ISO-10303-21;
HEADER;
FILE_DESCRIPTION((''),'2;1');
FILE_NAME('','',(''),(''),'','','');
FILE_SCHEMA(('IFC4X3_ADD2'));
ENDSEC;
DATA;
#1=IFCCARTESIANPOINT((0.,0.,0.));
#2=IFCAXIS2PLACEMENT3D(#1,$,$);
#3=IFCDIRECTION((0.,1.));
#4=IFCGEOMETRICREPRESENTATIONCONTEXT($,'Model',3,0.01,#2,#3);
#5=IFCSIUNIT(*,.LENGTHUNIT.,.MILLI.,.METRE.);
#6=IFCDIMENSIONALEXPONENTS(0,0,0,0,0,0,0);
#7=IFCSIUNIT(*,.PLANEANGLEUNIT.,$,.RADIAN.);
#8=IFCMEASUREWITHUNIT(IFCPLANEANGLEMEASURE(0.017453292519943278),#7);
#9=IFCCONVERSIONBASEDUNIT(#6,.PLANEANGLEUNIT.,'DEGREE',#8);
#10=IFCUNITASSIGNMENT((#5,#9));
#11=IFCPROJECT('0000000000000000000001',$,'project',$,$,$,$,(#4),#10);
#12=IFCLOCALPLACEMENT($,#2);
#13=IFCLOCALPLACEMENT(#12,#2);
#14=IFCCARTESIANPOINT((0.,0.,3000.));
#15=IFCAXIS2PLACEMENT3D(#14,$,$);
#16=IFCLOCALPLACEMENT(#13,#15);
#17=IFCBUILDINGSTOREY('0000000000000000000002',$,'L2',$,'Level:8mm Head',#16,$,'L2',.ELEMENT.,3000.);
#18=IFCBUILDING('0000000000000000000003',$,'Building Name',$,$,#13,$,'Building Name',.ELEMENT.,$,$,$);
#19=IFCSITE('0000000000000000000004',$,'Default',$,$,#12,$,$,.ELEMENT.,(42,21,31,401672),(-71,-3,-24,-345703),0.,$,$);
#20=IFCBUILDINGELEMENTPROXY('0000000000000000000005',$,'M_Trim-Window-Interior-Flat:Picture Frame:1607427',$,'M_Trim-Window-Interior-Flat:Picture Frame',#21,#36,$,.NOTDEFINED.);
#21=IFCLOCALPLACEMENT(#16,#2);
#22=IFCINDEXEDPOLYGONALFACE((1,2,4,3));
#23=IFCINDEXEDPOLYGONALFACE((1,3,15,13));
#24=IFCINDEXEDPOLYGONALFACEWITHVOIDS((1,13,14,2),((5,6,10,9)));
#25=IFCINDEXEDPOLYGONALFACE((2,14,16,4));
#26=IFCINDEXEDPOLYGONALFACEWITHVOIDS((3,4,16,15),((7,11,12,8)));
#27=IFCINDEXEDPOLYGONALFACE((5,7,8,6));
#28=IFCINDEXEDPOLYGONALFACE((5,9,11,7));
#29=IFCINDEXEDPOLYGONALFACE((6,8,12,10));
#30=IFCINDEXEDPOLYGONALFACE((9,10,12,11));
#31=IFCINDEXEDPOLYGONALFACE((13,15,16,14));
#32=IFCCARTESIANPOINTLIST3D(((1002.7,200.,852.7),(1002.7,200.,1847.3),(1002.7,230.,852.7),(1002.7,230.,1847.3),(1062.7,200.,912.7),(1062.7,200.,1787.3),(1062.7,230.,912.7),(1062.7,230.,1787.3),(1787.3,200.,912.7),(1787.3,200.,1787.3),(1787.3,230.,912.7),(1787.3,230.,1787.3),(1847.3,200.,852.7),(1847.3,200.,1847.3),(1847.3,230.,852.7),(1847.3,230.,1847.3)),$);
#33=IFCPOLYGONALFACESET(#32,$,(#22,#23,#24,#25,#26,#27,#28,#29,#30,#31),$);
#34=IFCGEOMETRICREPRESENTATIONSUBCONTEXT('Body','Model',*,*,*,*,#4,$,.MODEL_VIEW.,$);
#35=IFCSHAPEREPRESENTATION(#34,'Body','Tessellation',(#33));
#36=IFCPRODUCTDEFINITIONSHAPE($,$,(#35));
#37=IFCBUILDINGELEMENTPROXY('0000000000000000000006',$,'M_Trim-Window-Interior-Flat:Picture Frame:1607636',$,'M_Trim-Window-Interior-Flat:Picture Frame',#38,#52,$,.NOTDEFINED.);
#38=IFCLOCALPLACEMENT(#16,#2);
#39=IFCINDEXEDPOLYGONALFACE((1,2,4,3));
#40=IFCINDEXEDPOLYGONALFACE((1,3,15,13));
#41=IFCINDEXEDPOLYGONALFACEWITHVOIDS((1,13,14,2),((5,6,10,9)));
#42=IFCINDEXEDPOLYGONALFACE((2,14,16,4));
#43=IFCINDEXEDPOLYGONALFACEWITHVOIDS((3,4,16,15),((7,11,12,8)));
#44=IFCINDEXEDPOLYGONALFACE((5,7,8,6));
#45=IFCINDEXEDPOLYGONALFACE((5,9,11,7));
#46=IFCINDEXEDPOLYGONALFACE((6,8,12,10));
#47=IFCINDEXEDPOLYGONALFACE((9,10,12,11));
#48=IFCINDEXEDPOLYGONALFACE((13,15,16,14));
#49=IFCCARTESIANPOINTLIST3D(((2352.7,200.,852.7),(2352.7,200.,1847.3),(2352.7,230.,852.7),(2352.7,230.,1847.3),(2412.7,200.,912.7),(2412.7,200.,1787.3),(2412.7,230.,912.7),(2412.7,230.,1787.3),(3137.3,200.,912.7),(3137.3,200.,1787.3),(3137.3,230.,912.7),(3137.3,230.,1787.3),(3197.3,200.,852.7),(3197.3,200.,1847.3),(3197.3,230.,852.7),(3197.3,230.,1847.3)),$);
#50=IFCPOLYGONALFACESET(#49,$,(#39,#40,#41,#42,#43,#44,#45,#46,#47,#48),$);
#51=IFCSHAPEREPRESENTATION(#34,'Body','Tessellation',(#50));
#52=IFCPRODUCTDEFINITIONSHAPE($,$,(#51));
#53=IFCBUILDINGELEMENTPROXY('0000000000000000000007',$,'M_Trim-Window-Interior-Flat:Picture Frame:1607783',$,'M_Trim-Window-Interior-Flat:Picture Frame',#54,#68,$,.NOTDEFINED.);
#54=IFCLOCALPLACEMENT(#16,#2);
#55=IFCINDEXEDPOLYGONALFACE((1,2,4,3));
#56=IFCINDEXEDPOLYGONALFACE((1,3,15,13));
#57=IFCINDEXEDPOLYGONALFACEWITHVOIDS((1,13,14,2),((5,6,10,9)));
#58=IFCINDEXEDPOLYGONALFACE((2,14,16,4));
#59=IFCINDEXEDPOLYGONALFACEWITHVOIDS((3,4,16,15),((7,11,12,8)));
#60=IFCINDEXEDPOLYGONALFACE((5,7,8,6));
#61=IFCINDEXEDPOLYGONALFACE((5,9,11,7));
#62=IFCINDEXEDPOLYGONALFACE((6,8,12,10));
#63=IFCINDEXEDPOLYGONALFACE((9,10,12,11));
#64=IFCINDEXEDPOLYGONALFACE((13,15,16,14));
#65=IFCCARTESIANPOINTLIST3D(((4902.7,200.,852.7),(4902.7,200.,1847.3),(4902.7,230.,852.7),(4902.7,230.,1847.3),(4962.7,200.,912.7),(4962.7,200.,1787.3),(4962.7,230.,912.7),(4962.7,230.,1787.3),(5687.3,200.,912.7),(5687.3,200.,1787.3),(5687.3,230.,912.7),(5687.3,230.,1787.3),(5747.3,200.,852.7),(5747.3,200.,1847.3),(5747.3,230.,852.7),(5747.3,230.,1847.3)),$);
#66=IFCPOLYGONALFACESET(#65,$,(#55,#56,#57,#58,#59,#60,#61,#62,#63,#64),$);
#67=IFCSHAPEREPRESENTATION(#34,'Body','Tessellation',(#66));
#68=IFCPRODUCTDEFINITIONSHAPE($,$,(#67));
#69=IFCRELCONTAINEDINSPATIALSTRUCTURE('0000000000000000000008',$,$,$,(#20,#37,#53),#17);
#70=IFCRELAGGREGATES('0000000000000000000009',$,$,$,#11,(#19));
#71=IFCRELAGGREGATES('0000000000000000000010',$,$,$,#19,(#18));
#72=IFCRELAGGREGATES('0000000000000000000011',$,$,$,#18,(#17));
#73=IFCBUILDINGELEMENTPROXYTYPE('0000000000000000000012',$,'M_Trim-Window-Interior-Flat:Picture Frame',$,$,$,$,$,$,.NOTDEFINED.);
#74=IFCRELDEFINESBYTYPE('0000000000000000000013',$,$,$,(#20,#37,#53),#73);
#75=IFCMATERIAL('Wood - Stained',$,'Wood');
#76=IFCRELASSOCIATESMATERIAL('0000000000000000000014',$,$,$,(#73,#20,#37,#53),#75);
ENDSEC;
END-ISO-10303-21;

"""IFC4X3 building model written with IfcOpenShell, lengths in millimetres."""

from ifc_helpers import new_model, entity, si_unit, converted_unit, direction, frame, origin, place, context, subcontext, project, spatial, polyline, outline, extrude, source, transform, mapped, material, type_object, type_shapes, element, save


model = new_model("IFC4X3")

# Units and contexts
model_context = context("Model", 3, precision=0.01, world=origin(), true_north=direction((0.0, 1.0)))
body_context = subcontext(model_context, "Body", "Model", "MODEL_VIEW")
ifc_project = project(units=[si_unit("LENGTHUNIT", "METRE", prefix="MILLI"), converted_unit("PLANEANGLEUNIT", "DEGREE", entity("IfcPlaneAngleMeasure", 0.017453292519943278), si_unit("PLANEANGLEUNIT", "RADIAN"), dimensions=[0, 0, 0, 0, 0, 0, 0])], contexts=[model_context])

# Site, building, storey
site_placement = place(None, origin())
site = spatial("IfcSite", under=ifc_project, at=site_placement, Name="Default", CompositionType="ELEMENT", RefLatitude=(42, 21, 31, 401672), RefLongitude=(-71, -3, -24, -345703), RefElevation=0.0)
building_placement = place(site_placement, origin())
building = spatial("IfcBuilding", under=site, at=building_placement, Name="Building Name", LongName="Building Name", CompositionType="ELEMENT")
storey_placement = place(building_placement, frame((0.0, 0.0, 3000.0)))
storey = spatial("IfcBuildingStorey", under=building, at=storey_placement, Name="L2", ObjectType="Level:8mm Head", LongName="L2", CompositionType="ELEMENT", Elevation=3000.0)

# Building element proxies
ifc_material_1 = material(Name="Wood - Stained", Category="Wood")
building_element_proxy_type_1 = type_object("IfcBuildingElementProxyType", Name="M_Trim-Window-Interior-Flat:Picture Frame", PredefinedType="NOTDEFINED", material=ifc_material_1)
shared_shape_1 = source(origin(), body_context, "Body", "SweptSolid", [
    extrude(outline(polyline([(-422.3, -497.3), (422.3, -497.3), (422.3, 497.3), (-422.3, 497.3), (-422.3, -497.3)]), holes=[polyline([(-362.3, -437.3), (-362.3, 437.3), (362.3, 437.3), (362.3, -437.3), (-362.3, -437.3)])]), frame((0.0, -450.0, 0.0), z_axis=(0.0, 0.0, 1.0), x_axis=(-1.0, 0.0, 0.0)), (0.0, 0.0, 1.0), 30.0),
])
type_shapes(building_element_proxy_type_1, [shared_shape_1])
for number, where, z_axis, x_axis, name in (
    (1, (1425.0, 200.0, 1800.0), (0.0, 1.0, 0.0), (-1.0, 0.0, 0.0), "M_Trim-Window-Interior-Flat:Picture Frame:1607427"),
    (2, (2775.0, 200.0, 1800.0), (0.0, 1.0, 0.0), (-1.0, 0.0, 0.0), "M_Trim-Window-Interior-Flat:Picture Frame:1607636"),
    (3, (5325.0, 200.0, 1800.0), (0.0, 1.0, 0.0), (-1.0, 0.0, 0.0), "M_Trim-Window-Interior-Flat:Picture Frame:1607783"),
):
    element("IfcBuildingElementProxy", number, at=place(storey_placement, frame(where, z_axis=z_axis, x_axis=x_axis)), inside=storey, type_object=building_element_proxy_type_1, material=ifc_material_1, Name=name, ObjectType="M_Trim-Window-Interior-Flat:Picture Frame", PredefinedType="NOTDEFINED", context=body_context, shape_type="MappedRepresentation", body=[
        mapped(shared_shape_1, transform((0.0, 0.0, 0.0), scale=1.0)),
    ])

save(model, "model.ifc")
